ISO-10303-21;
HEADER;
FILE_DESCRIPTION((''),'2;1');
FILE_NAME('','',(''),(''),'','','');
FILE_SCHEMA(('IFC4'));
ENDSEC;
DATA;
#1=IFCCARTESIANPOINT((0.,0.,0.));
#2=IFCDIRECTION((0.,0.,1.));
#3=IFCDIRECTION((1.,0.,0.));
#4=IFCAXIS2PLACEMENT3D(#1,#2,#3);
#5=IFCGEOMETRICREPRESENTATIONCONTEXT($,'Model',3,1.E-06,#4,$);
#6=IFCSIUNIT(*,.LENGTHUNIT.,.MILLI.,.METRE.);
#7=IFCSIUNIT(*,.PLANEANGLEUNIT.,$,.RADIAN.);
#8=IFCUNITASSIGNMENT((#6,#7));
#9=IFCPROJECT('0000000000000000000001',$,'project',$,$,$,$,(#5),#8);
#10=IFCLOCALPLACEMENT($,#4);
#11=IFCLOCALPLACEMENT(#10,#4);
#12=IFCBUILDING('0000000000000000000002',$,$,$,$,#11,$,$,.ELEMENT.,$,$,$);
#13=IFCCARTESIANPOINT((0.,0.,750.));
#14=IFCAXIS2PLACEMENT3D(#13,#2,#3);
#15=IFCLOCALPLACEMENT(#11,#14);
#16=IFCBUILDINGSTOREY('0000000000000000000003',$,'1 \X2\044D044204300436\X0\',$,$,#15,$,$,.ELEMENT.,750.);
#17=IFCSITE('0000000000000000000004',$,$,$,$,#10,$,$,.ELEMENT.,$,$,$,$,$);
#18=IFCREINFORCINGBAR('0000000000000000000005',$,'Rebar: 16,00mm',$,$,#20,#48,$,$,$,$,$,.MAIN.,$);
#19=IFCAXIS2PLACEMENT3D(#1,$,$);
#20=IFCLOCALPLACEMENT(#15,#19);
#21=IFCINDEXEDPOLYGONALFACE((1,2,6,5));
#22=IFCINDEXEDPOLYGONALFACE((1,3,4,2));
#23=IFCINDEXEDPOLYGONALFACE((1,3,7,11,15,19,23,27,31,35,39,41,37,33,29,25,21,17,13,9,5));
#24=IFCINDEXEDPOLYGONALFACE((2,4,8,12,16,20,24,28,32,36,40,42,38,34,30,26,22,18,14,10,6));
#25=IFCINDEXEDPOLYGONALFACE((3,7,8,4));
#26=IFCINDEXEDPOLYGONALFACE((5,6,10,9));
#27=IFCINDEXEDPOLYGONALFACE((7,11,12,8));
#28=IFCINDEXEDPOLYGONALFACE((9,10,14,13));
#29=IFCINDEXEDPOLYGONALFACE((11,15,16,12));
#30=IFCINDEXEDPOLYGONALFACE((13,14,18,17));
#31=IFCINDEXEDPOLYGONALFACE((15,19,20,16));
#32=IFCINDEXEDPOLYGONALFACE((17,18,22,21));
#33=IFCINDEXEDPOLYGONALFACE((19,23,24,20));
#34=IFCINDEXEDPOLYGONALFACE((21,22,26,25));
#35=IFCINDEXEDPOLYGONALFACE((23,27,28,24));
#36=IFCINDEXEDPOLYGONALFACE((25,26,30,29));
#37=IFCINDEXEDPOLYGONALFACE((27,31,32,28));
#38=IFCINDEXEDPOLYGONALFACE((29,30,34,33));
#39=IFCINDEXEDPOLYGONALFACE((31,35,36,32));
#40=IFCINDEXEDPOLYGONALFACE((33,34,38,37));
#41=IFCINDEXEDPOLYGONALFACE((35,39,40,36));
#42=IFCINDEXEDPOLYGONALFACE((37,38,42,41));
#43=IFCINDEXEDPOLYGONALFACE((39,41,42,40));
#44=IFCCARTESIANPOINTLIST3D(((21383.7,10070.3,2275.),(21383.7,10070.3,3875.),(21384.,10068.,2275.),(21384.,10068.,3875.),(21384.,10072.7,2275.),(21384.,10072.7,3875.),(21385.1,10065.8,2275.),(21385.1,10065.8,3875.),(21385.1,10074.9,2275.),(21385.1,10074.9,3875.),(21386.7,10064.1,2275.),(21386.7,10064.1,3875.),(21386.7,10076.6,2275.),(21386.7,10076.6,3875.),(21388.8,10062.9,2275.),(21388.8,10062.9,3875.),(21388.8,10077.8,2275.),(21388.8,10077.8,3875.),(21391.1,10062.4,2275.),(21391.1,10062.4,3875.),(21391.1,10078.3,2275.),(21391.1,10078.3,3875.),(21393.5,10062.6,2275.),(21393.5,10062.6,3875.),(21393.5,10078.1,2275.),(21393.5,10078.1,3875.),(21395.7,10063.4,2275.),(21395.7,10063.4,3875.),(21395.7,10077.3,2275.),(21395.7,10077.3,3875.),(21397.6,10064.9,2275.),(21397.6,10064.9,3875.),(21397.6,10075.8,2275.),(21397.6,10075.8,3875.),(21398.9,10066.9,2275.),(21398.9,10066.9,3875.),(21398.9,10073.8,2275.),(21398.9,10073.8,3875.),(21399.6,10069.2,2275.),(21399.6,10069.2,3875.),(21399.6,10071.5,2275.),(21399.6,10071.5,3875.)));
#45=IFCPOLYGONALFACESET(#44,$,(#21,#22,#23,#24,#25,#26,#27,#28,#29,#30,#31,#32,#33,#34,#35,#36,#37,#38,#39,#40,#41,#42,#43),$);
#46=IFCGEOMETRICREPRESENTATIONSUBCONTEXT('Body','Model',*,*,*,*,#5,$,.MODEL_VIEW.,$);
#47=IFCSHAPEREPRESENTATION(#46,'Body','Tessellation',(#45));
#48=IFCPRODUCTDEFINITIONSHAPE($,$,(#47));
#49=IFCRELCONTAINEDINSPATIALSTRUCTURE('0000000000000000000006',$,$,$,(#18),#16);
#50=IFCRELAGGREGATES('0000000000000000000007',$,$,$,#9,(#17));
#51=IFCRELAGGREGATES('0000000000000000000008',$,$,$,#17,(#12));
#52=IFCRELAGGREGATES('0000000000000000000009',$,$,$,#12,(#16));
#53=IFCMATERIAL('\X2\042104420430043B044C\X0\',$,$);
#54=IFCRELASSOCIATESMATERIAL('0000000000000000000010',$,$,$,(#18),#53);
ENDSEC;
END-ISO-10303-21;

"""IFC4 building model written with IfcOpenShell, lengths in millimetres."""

from ifc_helpers import new_model, entity, si_unit, frame, origin_with_axes, place, context, subcontext, project, spatial, source, transform, mapped, material, element, save


model = new_model("IFC4")

# Units and contexts
model_context = context("Model", 3, precision=1e-06, world=origin_with_axes())
body_context = subcontext(model_context, "Body", "Model", "MODEL_VIEW")
ifc_project = project(units=[si_unit("LENGTHUNIT", "METRE", prefix="MILLI"), si_unit("PLANEANGLEUNIT", "RADIAN")], contexts=[model_context])

# Site, building, storey
site_placement = place(None, origin_with_axes())
site = spatial("IfcSite", under=ifc_project, at=site_placement, CompositionType="ELEMENT")
building_placement = place(site_placement, origin_with_axes())
building = spatial("IfcBuilding", under=site, at=building_placement, CompositionType="ELEMENT")
storey_placement = place(building_placement, frame((0.0, 0.0, 750.0), z_axis=(0.0, 0.0, 1.0), x_axis=(1.0, 0.0, 0.0)))
storey = spatial("IfcBuildingStorey", under=building, at=storey_placement, Name="1 этаж", CompositionType="ELEMENT", Elevation=750.0)

# Reinforcing bar
ifc_material = material(Name="Сталь")
shared_shape_1 = source(origin_with_axes(), body_context, "Body", "AdvancedSweptSolid", [
    entity("IfcSweptDiskSolid", entity("IfcIndexedPolyCurve", entity("IfcCartesianPointList3D", [[0.0, 0.0, 0.0], [1600.0, 0.0, 0.0]]), [entity("IfcLineIndex", [1, 2])]), 8.0),
])
reinforcing_bar_1_placement = place(storey_placement, origin_with_axes())
element("IfcReinforcingBar", 1, at=reinforcing_bar_1_placement, inside=storey, material=ifc_material, Name="Rebar: 16,00mm", PredefinedType="MAIN", context=body_context, shape_type="MappedRepresentation", body=[
    mapped(shared_shape_1, transform((21391.7, 10070.3, 2275.0), x_axis=(0.0, 0.0, 1.0), y_axis=(0.0, 1.0, 0.0), z_axis=(-1.0, 0.0, 0.0), scale=1.0)),
])

save(model, "model.ifc")
